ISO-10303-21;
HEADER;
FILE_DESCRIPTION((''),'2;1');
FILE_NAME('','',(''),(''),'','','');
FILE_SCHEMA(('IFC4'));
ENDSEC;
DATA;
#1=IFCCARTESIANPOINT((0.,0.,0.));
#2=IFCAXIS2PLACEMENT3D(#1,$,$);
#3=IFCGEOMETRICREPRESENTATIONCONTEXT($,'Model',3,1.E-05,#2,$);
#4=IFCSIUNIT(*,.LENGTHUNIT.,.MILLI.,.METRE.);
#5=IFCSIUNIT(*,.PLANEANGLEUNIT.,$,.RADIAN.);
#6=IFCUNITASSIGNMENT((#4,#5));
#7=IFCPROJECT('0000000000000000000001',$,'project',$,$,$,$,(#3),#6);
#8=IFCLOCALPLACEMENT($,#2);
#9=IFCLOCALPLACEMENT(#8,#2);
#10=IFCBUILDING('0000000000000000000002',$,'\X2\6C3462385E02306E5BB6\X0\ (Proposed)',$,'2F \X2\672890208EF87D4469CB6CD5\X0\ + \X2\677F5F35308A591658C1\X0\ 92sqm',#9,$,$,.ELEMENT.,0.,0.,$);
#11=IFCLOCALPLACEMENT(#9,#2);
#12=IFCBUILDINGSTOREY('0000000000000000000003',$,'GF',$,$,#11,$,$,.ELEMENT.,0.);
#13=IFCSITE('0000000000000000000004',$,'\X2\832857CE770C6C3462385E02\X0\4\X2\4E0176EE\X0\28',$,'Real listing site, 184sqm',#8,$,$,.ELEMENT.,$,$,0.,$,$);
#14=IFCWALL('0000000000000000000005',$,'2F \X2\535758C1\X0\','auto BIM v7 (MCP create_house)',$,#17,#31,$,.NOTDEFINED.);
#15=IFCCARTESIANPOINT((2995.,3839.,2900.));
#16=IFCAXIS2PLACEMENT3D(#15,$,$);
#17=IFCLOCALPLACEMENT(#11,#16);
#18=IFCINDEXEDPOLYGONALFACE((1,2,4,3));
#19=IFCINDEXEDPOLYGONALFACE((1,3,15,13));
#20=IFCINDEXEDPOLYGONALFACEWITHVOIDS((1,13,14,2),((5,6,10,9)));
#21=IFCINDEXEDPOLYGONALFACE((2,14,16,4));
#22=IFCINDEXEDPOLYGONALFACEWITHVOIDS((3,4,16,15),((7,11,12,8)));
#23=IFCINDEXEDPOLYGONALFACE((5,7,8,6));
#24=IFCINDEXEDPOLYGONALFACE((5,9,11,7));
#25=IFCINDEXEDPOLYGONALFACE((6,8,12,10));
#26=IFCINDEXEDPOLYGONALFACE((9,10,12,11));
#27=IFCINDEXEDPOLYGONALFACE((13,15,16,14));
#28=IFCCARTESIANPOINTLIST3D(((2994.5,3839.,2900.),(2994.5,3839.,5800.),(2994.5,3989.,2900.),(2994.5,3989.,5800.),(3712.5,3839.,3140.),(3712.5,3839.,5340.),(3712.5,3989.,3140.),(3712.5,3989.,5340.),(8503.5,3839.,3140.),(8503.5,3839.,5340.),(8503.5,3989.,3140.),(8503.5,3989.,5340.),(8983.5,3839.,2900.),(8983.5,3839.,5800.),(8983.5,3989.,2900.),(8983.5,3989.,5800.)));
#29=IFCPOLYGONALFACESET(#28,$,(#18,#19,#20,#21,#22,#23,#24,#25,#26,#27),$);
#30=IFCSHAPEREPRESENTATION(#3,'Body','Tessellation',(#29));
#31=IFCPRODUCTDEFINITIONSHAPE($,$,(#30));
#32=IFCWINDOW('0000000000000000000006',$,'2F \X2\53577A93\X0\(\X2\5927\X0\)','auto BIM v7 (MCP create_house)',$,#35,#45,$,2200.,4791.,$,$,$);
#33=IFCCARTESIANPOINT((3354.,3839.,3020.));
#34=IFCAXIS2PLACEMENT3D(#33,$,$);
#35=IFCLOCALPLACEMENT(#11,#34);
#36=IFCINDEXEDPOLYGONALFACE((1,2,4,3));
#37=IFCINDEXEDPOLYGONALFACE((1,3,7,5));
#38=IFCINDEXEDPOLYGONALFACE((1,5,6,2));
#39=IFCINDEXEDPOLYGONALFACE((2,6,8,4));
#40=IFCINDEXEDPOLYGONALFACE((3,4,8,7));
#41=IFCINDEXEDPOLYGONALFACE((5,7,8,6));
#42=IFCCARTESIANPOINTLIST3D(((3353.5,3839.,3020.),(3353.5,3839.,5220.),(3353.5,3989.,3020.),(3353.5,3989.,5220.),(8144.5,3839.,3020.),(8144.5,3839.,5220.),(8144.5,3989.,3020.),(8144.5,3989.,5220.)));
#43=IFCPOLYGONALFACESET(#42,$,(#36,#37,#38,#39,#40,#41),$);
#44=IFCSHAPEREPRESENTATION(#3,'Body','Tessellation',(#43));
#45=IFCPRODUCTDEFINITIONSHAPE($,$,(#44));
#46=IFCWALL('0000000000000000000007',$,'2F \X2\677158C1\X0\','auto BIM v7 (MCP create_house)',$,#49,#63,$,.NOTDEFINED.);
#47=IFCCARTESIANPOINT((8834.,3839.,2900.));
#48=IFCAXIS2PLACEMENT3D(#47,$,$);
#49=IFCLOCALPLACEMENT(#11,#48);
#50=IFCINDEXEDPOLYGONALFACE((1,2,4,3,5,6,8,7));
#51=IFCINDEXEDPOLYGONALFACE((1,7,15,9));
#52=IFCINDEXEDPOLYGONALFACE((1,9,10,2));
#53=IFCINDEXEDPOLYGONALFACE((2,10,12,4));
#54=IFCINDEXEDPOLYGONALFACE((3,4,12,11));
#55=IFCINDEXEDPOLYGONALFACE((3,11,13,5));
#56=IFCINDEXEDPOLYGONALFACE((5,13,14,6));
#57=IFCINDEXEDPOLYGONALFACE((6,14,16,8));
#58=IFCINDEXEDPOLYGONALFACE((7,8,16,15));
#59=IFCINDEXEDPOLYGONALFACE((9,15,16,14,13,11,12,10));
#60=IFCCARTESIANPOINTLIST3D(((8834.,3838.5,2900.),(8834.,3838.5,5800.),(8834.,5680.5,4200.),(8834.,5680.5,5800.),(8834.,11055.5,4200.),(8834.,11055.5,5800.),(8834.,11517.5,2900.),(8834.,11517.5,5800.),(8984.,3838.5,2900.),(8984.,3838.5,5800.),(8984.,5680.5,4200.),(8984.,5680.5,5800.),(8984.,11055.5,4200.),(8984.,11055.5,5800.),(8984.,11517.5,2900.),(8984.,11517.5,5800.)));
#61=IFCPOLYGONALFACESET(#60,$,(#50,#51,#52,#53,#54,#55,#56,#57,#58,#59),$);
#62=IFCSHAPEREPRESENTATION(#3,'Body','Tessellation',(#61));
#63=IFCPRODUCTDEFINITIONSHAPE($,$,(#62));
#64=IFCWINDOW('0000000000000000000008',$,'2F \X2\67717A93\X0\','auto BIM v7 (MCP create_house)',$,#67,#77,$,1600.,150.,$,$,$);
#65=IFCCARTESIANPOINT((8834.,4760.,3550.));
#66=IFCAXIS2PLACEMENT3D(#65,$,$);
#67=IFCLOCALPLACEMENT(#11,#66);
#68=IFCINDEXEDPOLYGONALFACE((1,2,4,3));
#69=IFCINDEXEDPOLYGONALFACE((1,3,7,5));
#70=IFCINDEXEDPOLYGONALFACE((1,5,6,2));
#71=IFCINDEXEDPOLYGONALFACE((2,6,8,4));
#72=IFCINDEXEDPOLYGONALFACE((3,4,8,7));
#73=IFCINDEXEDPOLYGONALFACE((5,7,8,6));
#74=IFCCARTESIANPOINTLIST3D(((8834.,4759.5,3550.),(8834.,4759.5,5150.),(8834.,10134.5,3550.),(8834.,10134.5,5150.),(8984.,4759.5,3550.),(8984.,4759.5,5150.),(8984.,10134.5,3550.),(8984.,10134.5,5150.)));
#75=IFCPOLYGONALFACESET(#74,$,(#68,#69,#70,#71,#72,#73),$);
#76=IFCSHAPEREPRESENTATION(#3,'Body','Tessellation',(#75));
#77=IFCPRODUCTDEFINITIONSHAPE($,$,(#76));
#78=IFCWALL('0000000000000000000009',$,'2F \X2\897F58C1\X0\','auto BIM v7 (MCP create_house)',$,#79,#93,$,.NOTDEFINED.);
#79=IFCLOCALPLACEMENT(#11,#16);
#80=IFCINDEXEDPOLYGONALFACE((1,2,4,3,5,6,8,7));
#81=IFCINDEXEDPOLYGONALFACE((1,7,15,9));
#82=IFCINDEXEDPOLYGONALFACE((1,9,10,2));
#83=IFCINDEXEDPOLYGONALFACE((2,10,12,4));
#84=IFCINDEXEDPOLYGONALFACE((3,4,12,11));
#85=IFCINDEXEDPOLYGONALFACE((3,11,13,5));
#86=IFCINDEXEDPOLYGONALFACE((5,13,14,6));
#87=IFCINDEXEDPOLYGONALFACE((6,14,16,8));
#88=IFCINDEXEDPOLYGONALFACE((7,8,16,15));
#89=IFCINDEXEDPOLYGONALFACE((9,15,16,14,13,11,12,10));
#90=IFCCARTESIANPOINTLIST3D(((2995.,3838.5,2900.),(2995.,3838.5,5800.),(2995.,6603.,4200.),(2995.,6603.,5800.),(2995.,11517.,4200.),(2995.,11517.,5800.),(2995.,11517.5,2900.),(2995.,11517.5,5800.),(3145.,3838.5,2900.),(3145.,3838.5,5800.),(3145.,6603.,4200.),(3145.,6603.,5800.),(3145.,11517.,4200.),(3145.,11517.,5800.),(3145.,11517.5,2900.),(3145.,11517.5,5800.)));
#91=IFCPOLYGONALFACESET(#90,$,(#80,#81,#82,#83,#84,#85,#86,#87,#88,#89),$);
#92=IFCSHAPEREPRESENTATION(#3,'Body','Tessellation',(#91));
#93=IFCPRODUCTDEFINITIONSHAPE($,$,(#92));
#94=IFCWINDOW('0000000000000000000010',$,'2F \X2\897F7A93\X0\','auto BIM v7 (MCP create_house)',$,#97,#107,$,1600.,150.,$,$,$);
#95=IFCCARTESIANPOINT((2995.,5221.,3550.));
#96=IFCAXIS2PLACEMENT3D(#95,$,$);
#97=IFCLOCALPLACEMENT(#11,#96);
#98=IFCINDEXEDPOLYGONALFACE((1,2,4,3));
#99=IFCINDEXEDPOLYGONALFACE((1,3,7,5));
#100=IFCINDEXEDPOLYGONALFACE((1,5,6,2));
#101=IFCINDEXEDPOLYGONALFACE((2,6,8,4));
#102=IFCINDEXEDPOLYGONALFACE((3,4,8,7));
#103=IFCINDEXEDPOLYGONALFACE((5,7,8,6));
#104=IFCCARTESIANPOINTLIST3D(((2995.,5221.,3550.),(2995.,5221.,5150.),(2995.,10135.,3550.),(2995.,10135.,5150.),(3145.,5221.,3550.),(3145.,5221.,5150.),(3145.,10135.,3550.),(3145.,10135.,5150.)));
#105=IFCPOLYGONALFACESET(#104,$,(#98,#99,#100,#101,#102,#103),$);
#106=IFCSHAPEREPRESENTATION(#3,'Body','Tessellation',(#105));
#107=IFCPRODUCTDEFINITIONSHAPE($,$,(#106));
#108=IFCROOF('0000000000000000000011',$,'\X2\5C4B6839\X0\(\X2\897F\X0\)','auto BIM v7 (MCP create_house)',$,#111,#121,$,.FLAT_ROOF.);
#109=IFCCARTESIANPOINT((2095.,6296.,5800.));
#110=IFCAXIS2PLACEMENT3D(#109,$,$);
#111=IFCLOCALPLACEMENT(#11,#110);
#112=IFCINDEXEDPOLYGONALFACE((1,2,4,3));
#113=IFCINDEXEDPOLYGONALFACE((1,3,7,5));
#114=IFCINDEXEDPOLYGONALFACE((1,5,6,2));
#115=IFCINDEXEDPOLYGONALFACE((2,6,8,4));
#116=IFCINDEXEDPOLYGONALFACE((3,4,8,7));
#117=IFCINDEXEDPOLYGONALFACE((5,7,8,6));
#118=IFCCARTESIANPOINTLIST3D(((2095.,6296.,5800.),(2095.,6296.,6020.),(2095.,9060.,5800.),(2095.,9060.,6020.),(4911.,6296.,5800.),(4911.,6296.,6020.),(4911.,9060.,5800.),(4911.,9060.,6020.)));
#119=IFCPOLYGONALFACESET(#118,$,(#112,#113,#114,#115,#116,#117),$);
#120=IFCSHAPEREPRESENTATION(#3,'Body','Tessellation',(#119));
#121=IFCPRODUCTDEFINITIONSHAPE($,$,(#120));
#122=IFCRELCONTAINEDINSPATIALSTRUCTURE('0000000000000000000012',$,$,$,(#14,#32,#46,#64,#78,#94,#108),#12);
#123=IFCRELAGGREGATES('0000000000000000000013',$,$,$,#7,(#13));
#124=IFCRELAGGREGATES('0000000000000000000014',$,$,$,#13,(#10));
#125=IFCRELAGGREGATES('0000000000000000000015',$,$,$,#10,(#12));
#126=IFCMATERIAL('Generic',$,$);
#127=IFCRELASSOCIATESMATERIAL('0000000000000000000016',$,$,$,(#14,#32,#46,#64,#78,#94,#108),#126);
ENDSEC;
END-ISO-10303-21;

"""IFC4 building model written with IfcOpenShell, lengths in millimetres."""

from ifc_helpers import new_model, si_unit, frame, frame_2d, origin, place, context, project, spatial, rectangle, extrude, material, element, fill, save


model = new_model("IFC4")

# Units and contexts
model_context = context("Model", 3, precision=1e-05, world=origin())
ifc_project = project(units=[si_unit("LENGTHUNIT", "METRE", prefix="MILLI"), si_unit("PLANEANGLEUNIT", "RADIAN")], contexts=[model_context])

# Site, building, storey
site_placement = place(None, origin())
site = spatial("IfcSite", under=ifc_project, at=site_placement, Name="茨城県水戸市4丁目28", ObjectType="Real listing site, 184sqm", CompositionType="ELEMENT", RefElevation=0.0)
building_placement = place(site_placement, origin())
building = spatial("IfcBuilding", under=site, at=building_placement, Name="水戸市の家 (Proposed)", ObjectType="2F 木造軸組構法 + 板張り外壁 92sqm", CompositionType="ELEMENT", ElevationOfRefHeight=0.0, ElevationOfTerrain=0.0)
storey_placement = place(building_placement, origin())
storey = spatial("IfcBuildingStorey", under=building, at=storey_placement, Name="GF", CompositionType="ELEMENT", Elevation=0.0)

# Shared definitions
ifc_material = material(Name="Generic")

# Walls, openings, windows
wall_1_placement = place(storey_placement, frame((2995.0, 3839.0, 2900.0)))
wall_1 = element("IfcWall", 1, at=wall_1_placement, inside=storey, material=ifc_material, Name="2F 南壁", Description="auto BIM v7 (MCP create_house)", PredefinedType="NOTDEFINED", context=model_context, shape_type="SweptSolid", body=[
    extrude(rectangle(XDim=5989.0, YDim=150.0, at=frame_2d((2994.0, 75.0))), frame((2995.0, 3839.0, 2900.0)), (0.0, 0.0, 1.0), 2900.0),
])
opening_1_placement = place(storey_placement, frame((3354.0, 3839.0, 3020.0)))
opening_1 = element("IfcOpeningElement", 2, at=opening_1_placement, cuts=wall_1, PredefinedType="NOTDEFINED", context=model_context, shape_type="SweptSolid", body=[
    extrude(rectangle(XDim=4791.0, YDim=150.0, at=frame_2d((2395.0, 75.0))), frame((3354.0, 3839.0, 3020.0)), (0.0, 0.0, 1.0), 2200.0),
])
window_1_placement = place(storey_placement, frame((3354.0, 3839.0, 3020.0)))
window_1 = element("IfcWindow", 3, at=window_1_placement, inside=storey, material=ifc_material, Name="2F 南窓(大)", Description="auto BIM v7 (MCP create_house)", OverallHeight=2200.0, OverallWidth=4791.0, context=model_context, shape_type="SweptSolid", body=[
    extrude(rectangle(XDim=4791.0, YDim=150.0, at=frame_2d((2395.0, 75.0))), frame((3354.0, 3839.0, 3020.0)), (0.0, 0.0, 1.0), 2200.0),
])
fill(opening_1, window_1)
wall_2_placement = place(storey_placement, frame((8834.0, 3839.0, 2900.0)))
wall_2 = element("IfcWall", 4, at=wall_2_placement, inside=storey, material=ifc_material, Name="2F 東壁", Description="auto BIM v7 (MCP create_house)", PredefinedType="NOTDEFINED", context=model_context, shape_type="SweptSolid", body=[
    extrude(rectangle(XDim=150.0, YDim=7679.0, at=frame_2d((75.0, 3839.0))), frame((8834.0, 3839.0, 2900.0)), (0.0, 0.0, 1.0), 2900.0),
])
opening_2_placement = place(storey_placement, frame((8834.0, 4760.0, 3550.0)))
opening_2 = element("IfcOpeningElement", 5, at=opening_2_placement, cuts=wall_2, PredefinedType="NOTDEFINED", context=model_context, shape_type="SweptSolid", body=[
    extrude(rectangle(XDim=150.0, YDim=5375.0, at=frame_2d((75.0, 2687.0))), frame((8834.0, 4760.0, 3550.0)), (0.0, 0.0, 1.0), 1600.0),
])
window_2_placement = place(storey_placement, frame((8834.0, 4760.0, 3550.0)))
window_2 = element("IfcWindow", 6, at=window_2_placement, inside=storey, material=ifc_material, Name="2F 東窓", Description="auto BIM v7 (MCP create_house)", OverallHeight=1600.0, OverallWidth=150.0, context=model_context, shape_type="SweptSolid", body=[
    extrude(rectangle(XDim=150.0, YDim=5375.0, at=frame_2d((75.0, 2687.0))), frame((8834.0, 4760.0, 3550.0)), (0.0, 0.0, 1.0), 1600.0),
])
fill(opening_2, window_2)
wall_3_placement = place(storey_placement, frame((2995.0, 3839.0, 2900.0)))
wall_3 = element("IfcWall", 7, at=wall_3_placement, inside=storey, material=ifc_material, Name="2F 西壁", Description="auto BIM v7 (MCP create_house)", PredefinedType="NOTDEFINED", context=model_context, shape_type="SweptSolid", body=[
    extrude(rectangle(XDim=150.0, YDim=7679.0, at=frame_2d((75.0, 3839.0))), frame((2995.0, 3839.0, 2900.0)), (0.0, 0.0, 1.0), 2900.0),
])
opening_3_placement = place(storey_placement, frame((2995.0, 5221.0, 3550.0)))
opening_3 = element("IfcOpeningElement", 8, at=opening_3_placement, cuts=wall_3, PredefinedType="NOTDEFINED", context=model_context, shape_type="SweptSolid", body=[
    extrude(rectangle(XDim=150.0, YDim=4914.0, at=frame_2d((75.0, 2457.0))), frame((2995.0, 5221.0, 3550.0)), (0.0, 0.0, 1.0), 1600.0),
])
window_3_placement = place(storey_placement, frame((2995.0, 5221.0, 3550.0)))
window_3 = element("IfcWindow", 9, at=window_3_placement, inside=storey, material=ifc_material, Name="2F 西窓", Description="auto BIM v7 (MCP create_house)", OverallHeight=1600.0, OverallWidth=150.0, context=model_context, shape_type="SweptSolid", body=[
    extrude(rectangle(XDim=150.0, YDim=4914.0, at=frame_2d((75.0, 2457.0))), frame((2995.0, 5221.0, 3550.0)), (0.0, 0.0, 1.0), 1600.0),
])
fill(opening_3, window_3)

# Roof
roof_1_placement = place(storey_placement, frame((2095.0, 6296.0, 5800.0)))
element("IfcRoof", 10, at=roof_1_placement, inside=storey, material=ifc_material, Name="屋根(西)", Description="auto BIM v7 (MCP create_house)", PredefinedType="FLAT_ROOF", context=model_context, shape_type="SweptSolid", body=[
    extrude(rectangle(XDim=2816.0, YDim=2764.0, at=frame_2d((1408.0, 1382.0))), frame((2095.0, 6296.0, 5800.0)), (0.0, 0.0, 1.0), 220.0),
])

save(model, "model.ifc")
